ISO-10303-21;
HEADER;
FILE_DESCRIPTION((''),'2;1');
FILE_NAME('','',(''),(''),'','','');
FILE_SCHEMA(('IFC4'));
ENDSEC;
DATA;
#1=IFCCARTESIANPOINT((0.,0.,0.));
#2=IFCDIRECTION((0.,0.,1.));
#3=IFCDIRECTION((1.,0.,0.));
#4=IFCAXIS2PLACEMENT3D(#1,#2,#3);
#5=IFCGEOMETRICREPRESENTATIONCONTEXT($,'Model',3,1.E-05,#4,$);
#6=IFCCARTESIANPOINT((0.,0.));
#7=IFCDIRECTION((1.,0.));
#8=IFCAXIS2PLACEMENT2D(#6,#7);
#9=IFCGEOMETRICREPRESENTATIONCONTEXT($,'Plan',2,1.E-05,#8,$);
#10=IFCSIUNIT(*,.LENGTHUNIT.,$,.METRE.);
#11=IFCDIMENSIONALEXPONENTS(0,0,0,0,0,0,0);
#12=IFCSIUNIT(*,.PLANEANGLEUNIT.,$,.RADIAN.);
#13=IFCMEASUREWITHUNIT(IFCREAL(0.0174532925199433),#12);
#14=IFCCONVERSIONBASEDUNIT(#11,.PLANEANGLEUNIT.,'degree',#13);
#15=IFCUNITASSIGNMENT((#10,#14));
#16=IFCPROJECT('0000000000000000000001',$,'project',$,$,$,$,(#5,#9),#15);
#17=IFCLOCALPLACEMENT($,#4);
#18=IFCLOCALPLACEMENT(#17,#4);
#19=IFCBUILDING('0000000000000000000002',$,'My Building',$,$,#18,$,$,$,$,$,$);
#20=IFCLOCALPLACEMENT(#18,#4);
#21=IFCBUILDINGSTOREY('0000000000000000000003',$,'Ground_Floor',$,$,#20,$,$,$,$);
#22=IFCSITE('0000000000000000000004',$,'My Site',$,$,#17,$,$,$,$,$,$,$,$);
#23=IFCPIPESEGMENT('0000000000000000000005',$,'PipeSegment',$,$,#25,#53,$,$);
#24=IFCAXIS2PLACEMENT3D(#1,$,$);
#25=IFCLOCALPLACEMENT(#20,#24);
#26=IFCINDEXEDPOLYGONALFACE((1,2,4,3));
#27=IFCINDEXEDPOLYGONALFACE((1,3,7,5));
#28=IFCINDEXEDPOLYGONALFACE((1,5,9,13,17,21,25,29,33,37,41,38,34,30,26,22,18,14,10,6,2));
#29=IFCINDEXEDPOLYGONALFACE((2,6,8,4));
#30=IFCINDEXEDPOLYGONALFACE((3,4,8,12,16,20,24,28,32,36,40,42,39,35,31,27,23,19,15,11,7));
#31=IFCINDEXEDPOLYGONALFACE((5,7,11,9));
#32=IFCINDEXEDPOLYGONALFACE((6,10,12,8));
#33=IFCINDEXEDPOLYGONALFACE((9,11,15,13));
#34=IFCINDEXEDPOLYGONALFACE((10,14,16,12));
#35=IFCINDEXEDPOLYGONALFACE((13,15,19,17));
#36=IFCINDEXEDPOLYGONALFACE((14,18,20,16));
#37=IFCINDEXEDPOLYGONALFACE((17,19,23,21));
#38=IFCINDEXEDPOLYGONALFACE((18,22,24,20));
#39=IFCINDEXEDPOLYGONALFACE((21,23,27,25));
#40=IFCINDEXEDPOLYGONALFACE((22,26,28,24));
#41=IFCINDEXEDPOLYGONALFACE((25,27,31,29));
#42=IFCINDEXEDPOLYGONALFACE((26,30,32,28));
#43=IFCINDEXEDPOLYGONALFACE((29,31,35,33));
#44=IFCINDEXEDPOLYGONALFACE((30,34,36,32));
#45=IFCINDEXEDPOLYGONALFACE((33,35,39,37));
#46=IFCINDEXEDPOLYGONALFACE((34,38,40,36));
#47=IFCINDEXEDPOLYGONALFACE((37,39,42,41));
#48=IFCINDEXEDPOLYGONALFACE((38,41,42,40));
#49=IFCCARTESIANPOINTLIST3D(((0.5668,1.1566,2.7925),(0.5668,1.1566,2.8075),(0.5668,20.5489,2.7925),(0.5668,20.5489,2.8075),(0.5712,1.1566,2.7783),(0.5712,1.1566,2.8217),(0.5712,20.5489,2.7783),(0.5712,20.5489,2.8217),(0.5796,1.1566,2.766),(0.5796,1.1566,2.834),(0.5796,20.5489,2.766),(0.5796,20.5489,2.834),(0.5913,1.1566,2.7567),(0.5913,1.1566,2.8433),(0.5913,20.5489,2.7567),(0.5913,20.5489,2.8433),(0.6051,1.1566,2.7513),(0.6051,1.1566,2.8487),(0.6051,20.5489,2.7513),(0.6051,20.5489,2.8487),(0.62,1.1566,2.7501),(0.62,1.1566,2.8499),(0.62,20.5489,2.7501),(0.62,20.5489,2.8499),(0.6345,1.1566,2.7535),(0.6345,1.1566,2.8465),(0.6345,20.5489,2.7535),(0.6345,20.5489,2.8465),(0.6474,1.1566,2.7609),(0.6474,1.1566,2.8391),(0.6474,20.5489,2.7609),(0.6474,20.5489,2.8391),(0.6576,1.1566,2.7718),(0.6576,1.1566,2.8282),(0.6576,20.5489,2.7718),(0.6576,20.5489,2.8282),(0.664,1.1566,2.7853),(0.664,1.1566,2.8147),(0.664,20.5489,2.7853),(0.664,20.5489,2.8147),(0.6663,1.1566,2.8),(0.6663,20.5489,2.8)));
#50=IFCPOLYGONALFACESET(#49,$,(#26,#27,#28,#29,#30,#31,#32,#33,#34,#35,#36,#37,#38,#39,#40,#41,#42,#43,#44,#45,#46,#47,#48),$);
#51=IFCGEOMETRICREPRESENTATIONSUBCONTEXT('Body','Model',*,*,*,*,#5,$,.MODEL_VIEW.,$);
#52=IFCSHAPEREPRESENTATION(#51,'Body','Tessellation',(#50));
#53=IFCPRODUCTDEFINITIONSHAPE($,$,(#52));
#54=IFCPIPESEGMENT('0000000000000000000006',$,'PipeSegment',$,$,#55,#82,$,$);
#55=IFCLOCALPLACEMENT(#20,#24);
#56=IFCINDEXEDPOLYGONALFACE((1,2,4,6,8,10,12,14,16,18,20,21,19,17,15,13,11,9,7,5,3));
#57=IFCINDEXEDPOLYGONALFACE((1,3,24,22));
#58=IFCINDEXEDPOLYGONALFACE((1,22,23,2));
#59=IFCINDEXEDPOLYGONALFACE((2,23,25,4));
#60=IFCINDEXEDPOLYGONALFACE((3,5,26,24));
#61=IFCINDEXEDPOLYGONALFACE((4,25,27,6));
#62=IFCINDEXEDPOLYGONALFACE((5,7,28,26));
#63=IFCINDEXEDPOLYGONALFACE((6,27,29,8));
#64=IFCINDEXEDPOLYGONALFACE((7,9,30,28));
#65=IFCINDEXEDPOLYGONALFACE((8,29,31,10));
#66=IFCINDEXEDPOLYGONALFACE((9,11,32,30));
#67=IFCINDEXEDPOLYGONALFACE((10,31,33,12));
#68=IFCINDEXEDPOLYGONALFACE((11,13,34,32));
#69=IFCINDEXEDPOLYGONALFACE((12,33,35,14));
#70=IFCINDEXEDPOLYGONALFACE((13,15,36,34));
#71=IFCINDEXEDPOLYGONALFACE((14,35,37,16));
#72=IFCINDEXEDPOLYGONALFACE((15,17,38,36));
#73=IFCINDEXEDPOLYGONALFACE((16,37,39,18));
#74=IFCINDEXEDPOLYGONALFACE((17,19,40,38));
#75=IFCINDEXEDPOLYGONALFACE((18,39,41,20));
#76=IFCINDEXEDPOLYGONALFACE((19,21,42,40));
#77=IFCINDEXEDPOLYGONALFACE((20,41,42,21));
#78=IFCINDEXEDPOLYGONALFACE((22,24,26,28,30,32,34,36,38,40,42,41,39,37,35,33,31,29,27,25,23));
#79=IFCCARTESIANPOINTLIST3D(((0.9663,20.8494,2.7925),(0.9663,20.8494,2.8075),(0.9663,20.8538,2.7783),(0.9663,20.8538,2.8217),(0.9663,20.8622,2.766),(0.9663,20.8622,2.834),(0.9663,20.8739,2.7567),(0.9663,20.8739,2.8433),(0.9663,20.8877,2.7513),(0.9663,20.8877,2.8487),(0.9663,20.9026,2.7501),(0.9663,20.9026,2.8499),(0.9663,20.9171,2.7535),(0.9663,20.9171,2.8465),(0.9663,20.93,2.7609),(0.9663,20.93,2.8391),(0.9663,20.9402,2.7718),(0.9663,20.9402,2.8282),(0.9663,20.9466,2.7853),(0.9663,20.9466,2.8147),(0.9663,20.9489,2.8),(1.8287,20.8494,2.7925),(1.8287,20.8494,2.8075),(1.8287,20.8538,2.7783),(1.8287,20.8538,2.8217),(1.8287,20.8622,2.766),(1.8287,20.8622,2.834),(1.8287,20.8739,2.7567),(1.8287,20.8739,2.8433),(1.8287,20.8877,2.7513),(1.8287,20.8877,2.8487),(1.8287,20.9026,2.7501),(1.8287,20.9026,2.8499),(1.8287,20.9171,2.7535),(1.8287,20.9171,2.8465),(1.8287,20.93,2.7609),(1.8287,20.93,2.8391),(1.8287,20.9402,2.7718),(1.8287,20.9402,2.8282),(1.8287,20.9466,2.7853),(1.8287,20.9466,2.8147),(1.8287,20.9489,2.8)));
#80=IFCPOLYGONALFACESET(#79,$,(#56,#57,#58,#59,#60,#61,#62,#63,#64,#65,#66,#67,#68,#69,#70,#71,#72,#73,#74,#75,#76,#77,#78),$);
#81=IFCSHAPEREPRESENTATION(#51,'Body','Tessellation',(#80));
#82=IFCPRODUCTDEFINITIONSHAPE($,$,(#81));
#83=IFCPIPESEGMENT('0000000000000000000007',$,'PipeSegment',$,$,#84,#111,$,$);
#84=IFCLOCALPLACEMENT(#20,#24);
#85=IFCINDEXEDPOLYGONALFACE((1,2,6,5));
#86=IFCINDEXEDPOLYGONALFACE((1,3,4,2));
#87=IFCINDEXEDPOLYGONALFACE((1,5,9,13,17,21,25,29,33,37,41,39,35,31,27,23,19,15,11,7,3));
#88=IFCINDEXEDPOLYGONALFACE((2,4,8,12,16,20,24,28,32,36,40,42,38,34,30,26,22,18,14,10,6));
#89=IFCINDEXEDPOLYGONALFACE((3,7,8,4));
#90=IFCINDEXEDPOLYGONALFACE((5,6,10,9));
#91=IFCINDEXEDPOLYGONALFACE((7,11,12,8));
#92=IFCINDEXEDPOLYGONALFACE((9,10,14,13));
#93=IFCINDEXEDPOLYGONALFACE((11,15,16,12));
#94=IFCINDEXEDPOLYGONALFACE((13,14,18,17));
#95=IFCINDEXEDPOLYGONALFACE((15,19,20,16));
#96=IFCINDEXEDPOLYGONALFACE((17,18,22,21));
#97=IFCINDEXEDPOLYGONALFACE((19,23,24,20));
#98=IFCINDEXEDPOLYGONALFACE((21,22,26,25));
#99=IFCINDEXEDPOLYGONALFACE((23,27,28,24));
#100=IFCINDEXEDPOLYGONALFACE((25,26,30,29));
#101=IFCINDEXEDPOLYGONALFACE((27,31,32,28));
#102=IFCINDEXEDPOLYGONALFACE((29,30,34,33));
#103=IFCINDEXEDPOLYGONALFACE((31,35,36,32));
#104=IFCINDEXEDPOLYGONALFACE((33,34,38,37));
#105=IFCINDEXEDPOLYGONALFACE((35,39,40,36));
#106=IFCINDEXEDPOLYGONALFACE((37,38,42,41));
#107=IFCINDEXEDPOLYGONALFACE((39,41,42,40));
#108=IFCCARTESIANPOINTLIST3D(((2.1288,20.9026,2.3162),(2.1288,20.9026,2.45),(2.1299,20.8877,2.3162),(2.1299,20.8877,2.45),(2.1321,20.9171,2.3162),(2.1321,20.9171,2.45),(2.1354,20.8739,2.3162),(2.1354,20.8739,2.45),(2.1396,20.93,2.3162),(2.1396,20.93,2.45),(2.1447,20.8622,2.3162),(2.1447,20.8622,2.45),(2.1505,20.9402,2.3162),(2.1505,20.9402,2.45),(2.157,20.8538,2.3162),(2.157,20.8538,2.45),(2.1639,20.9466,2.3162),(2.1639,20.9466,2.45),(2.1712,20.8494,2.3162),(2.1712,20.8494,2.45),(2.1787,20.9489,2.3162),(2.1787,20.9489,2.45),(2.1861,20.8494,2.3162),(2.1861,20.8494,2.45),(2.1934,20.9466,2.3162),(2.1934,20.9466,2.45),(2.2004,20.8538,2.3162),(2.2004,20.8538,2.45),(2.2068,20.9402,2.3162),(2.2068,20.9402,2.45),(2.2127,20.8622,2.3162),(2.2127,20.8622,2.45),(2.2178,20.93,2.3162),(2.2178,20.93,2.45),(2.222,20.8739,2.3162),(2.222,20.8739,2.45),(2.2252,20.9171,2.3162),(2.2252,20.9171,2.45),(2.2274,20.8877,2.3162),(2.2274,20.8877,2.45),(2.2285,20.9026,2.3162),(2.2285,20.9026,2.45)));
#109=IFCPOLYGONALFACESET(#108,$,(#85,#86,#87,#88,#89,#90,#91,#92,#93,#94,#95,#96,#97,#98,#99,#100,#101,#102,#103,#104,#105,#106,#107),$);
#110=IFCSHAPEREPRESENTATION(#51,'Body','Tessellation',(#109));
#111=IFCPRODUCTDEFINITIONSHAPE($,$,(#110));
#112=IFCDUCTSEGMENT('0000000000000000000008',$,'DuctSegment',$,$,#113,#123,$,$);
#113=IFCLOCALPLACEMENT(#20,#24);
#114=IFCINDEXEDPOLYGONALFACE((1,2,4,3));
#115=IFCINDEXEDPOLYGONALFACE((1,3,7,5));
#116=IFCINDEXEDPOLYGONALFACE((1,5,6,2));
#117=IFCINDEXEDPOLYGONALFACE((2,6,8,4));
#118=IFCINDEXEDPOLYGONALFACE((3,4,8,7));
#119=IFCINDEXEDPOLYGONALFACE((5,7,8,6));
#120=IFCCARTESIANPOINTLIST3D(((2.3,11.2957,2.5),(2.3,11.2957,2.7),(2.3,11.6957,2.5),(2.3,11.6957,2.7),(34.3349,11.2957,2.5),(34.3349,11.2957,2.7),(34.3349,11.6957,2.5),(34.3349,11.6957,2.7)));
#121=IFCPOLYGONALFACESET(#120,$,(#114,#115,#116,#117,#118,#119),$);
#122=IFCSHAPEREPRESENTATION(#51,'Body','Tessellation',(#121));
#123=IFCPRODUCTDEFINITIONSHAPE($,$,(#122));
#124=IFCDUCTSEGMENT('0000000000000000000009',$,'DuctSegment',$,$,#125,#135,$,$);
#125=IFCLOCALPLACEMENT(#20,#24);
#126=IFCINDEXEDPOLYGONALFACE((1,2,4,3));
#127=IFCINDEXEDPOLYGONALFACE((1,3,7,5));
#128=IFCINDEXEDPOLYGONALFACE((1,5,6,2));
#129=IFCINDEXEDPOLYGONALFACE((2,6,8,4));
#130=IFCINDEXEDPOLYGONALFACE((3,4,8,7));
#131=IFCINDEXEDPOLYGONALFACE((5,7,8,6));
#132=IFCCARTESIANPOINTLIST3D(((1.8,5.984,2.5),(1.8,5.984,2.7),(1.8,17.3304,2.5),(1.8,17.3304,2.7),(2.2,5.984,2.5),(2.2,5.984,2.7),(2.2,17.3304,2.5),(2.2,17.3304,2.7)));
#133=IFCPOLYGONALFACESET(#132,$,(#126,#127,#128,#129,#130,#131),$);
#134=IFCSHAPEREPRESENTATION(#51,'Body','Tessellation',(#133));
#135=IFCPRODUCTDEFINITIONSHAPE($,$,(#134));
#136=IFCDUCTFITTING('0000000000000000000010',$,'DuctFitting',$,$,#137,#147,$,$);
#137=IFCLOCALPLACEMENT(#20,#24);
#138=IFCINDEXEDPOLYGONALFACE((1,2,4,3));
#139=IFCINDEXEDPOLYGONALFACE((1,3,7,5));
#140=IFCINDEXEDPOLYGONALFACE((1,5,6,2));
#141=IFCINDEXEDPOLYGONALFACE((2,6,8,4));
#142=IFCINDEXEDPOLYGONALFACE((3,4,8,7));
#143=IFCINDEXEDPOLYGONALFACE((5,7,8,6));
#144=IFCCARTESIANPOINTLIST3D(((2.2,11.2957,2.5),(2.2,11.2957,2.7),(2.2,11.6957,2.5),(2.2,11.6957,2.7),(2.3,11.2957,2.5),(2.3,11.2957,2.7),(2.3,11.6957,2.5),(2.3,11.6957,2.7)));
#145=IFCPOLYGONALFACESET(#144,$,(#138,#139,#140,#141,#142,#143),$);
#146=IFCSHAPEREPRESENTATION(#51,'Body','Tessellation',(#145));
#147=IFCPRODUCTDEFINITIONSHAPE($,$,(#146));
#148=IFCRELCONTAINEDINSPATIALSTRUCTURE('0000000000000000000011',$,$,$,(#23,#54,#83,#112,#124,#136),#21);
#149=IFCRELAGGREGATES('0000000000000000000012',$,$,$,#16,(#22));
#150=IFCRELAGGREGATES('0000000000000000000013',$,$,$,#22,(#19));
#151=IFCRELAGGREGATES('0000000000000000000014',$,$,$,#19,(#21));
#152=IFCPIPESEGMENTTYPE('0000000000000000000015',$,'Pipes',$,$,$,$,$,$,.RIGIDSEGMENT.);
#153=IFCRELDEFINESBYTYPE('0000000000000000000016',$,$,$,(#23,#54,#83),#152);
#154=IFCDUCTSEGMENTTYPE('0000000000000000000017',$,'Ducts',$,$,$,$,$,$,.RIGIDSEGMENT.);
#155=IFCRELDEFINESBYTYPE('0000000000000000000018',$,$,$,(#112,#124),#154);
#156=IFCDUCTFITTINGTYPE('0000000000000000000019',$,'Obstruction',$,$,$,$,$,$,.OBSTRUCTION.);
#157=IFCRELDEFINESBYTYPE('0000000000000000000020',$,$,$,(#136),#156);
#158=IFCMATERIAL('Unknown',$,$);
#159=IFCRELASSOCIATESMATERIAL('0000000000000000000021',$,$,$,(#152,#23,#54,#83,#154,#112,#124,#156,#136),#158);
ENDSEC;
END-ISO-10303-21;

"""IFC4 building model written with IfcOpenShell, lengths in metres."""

from ifc_helpers import new_model, entity, si_unit, converted_unit, frame, origin_with_axes, origin_2d_with_axis, place, context, subcontext, project, spatial, rectangle, circle, extrude, material, material_profile, profile_set, profile_usage, type_object, element, save


model = new_model("IFC4")

# Units and contexts
model_context = context("Model", 3, precision=1e-05, world=origin_with_axes())
plan_context = context("Plan", 2, precision=1e-05, world=origin_2d_with_axis())
body_context = subcontext(model_context, "Body", "Model", "MODEL_VIEW")
ifc_project = project(units=[si_unit("LENGTHUNIT", "METRE"), converted_unit("PLANEANGLEUNIT", "degree", entity("IfcReal", 0.0174532925199433), si_unit("PLANEANGLEUNIT", "RADIAN"), dimensions=[0, 0, 0, 0, 0, 0, 0])], contexts=[model_context, plan_context])

# Site, building, storey
site_placement = place(None, origin_with_axes())
site = spatial("IfcSite", under=ifc_project, at=site_placement, Name="My Site")
building_placement = place(site_placement, origin_with_axes())
building = spatial("IfcBuilding", under=site, at=building_placement, Name="My Building")
storey_placement = place(building_placement, origin_with_axes())
storey = spatial("IfcBuildingStorey", under=building, at=storey_placement, Name="Ground_Floor")

# Shared definitions
ifc_material = material(Name="Unknown")

# Pipe segments
ifc_material_profile_1 = material_profile(ifc_material, circle(Radius=0.05))
ifc_profile_set_1 = profile_set([ifc_material_profile_1])
ifc_profile_usage_1 = profile_usage(ifc_profile_set_1, cardinal=5)
pipe_segment_type = type_object("IfcPipeSegmentType", Name="Pipes", PredefinedType="RIGIDSEGMENT", material=ifc_profile_set_1)
pipe_segment_1_placement = place(storey_placement, frame((0.6163, 20.5489, 2.8), z_axis=(0.0, -1.0, 0.0), x_axis=(1.0, 0.0, 0.0)))
element("IfcPipeSegment", 1, at=pipe_segment_1_placement, inside=storey, type_object=pipe_segment_type, material=ifc_profile_usage_1, Name="PipeSegment", context=body_context, shape_type="SweptSolid", body=[
    extrude(circle(Radius=0.05), origin_with_axes(), (0.0, 0.0, 1.0), 19.3922),
])
ifc_profile_usage_2 = profile_usage(ifc_profile_set_1, cardinal=5)
pipe_segment_2_placement = place(storey_placement, frame((0.9663, 20.8989, 2.8), z_axis=(1.0, 0.0, 0.0), x_axis=(0.0, 1.0, 0.0)))
element("IfcPipeSegment", 2, at=pipe_segment_2_placement, inside=storey, type_object=pipe_segment_type, material=ifc_profile_usage_2, Name="PipeSegment", context=body_context, shape_type="SweptSolid", body=[
    extrude(circle(Radius=0.05), origin_with_axes(), (0.0, 0.0, 1.0), 0.8624),
])
ifc_profile_usage_3 = profile_usage(ifc_profile_set_1, cardinal=5)
pipe_segment_3_placement = place(storey_placement, frame((2.1787, 20.8989, 2.45), z_axis=(0.0, 0.0, -1.0), x_axis=(0.0, 1.0, 0.0)))
element("IfcPipeSegment", 3, at=pipe_segment_3_placement, inside=storey, type_object=pipe_segment_type, material=ifc_profile_usage_3, Name="PipeSegment", context=body_context, shape_type="SweptSolid", body=[
    extrude(circle(Radius=0.05), origin_with_axes(), (0.0, 0.0, 1.0), 0.1338),
])

# Duct segments
ifc_material_profile_2 = material_profile(ifc_material, rectangle(XDim=0.4, YDim=0.2))
ifc_profile_set_2 = profile_set([ifc_material_profile_2])
ifc_profile_usage_4 = profile_usage(ifc_profile_set_2, cardinal=5)
duct_segment_type = type_object("IfcDuctSegmentType", Name="Ducts", PredefinedType="RIGIDSEGMENT", material=ifc_profile_set_2)
duct_segment_1_placement = place(storey_placement, frame((2.3, 11.4957, 2.6), z_axis=(1.0, 0.0, 0.0), x_axis=(0.0, 1.0, 0.0)))
element("IfcDuctSegment", 4, at=duct_segment_1_placement, inside=storey, type_object=duct_segment_type, material=ifc_profile_usage_4, Name="DuctSegment", context=body_context, shape_type="SweptSolid", body=[
    extrude(rectangle(XDim=0.4, YDim=0.2), origin_with_axes(), (0.0, 0.0, 1.0), 32.0349),
])
ifc_profile_usage_5 = profile_usage(ifc_profile_set_2, cardinal=5)
duct_segment_2_placement = place(storey_placement, frame((2.0, 17.3304, 2.6), z_axis=(0.0, -1.0, 0.0), x_axis=(1.0, 0.0, 0.0)))
element("IfcDuctSegment", 5, at=duct_segment_2_placement, inside=storey, type_object=duct_segment_type, material=ifc_profile_usage_5, Name="DuctSegment", context=body_context, shape_type="SweptSolid", body=[
    extrude(rectangle(XDim=0.4, YDim=0.2), origin_with_axes(), (0.0, 0.0, 1.0), 11.3464),
])

# Duct fitting
ifc_material_profile_3 = material_profile(ifc_material, rectangle(XDim=0.4, YDim=0.2))
ifc_profile_set_3 = profile_set([ifc_material_profile_3])
ifc_profile_usage_6 = profile_usage(ifc_profile_set_3, cardinal=5)
duct_fitting_type = type_object("IfcDuctFittingType", Name="Obstruction", PredefinedType="OBSTRUCTION", material=ifc_profile_set_3)
duct_fitting_placement = place(storey_placement, frame((2.2, 11.4957, 2.6), z_axis=(1.0, 0.0, 0.0), x_axis=(0.0, 1.0, 0.0)))
element("IfcDuctFitting", 6, at=duct_fitting_placement, inside=storey, type_object=duct_fitting_type, material=ifc_profile_usage_6, Name="DuctFitting", context=body_context, shape_type="SweptSolid", body=[
    extrude(rectangle(XDim=0.4, YDim=0.2), origin_with_axes(), (0.0, 0.0, 1.0), 0.1),
])

save(model, "model.ifc")
